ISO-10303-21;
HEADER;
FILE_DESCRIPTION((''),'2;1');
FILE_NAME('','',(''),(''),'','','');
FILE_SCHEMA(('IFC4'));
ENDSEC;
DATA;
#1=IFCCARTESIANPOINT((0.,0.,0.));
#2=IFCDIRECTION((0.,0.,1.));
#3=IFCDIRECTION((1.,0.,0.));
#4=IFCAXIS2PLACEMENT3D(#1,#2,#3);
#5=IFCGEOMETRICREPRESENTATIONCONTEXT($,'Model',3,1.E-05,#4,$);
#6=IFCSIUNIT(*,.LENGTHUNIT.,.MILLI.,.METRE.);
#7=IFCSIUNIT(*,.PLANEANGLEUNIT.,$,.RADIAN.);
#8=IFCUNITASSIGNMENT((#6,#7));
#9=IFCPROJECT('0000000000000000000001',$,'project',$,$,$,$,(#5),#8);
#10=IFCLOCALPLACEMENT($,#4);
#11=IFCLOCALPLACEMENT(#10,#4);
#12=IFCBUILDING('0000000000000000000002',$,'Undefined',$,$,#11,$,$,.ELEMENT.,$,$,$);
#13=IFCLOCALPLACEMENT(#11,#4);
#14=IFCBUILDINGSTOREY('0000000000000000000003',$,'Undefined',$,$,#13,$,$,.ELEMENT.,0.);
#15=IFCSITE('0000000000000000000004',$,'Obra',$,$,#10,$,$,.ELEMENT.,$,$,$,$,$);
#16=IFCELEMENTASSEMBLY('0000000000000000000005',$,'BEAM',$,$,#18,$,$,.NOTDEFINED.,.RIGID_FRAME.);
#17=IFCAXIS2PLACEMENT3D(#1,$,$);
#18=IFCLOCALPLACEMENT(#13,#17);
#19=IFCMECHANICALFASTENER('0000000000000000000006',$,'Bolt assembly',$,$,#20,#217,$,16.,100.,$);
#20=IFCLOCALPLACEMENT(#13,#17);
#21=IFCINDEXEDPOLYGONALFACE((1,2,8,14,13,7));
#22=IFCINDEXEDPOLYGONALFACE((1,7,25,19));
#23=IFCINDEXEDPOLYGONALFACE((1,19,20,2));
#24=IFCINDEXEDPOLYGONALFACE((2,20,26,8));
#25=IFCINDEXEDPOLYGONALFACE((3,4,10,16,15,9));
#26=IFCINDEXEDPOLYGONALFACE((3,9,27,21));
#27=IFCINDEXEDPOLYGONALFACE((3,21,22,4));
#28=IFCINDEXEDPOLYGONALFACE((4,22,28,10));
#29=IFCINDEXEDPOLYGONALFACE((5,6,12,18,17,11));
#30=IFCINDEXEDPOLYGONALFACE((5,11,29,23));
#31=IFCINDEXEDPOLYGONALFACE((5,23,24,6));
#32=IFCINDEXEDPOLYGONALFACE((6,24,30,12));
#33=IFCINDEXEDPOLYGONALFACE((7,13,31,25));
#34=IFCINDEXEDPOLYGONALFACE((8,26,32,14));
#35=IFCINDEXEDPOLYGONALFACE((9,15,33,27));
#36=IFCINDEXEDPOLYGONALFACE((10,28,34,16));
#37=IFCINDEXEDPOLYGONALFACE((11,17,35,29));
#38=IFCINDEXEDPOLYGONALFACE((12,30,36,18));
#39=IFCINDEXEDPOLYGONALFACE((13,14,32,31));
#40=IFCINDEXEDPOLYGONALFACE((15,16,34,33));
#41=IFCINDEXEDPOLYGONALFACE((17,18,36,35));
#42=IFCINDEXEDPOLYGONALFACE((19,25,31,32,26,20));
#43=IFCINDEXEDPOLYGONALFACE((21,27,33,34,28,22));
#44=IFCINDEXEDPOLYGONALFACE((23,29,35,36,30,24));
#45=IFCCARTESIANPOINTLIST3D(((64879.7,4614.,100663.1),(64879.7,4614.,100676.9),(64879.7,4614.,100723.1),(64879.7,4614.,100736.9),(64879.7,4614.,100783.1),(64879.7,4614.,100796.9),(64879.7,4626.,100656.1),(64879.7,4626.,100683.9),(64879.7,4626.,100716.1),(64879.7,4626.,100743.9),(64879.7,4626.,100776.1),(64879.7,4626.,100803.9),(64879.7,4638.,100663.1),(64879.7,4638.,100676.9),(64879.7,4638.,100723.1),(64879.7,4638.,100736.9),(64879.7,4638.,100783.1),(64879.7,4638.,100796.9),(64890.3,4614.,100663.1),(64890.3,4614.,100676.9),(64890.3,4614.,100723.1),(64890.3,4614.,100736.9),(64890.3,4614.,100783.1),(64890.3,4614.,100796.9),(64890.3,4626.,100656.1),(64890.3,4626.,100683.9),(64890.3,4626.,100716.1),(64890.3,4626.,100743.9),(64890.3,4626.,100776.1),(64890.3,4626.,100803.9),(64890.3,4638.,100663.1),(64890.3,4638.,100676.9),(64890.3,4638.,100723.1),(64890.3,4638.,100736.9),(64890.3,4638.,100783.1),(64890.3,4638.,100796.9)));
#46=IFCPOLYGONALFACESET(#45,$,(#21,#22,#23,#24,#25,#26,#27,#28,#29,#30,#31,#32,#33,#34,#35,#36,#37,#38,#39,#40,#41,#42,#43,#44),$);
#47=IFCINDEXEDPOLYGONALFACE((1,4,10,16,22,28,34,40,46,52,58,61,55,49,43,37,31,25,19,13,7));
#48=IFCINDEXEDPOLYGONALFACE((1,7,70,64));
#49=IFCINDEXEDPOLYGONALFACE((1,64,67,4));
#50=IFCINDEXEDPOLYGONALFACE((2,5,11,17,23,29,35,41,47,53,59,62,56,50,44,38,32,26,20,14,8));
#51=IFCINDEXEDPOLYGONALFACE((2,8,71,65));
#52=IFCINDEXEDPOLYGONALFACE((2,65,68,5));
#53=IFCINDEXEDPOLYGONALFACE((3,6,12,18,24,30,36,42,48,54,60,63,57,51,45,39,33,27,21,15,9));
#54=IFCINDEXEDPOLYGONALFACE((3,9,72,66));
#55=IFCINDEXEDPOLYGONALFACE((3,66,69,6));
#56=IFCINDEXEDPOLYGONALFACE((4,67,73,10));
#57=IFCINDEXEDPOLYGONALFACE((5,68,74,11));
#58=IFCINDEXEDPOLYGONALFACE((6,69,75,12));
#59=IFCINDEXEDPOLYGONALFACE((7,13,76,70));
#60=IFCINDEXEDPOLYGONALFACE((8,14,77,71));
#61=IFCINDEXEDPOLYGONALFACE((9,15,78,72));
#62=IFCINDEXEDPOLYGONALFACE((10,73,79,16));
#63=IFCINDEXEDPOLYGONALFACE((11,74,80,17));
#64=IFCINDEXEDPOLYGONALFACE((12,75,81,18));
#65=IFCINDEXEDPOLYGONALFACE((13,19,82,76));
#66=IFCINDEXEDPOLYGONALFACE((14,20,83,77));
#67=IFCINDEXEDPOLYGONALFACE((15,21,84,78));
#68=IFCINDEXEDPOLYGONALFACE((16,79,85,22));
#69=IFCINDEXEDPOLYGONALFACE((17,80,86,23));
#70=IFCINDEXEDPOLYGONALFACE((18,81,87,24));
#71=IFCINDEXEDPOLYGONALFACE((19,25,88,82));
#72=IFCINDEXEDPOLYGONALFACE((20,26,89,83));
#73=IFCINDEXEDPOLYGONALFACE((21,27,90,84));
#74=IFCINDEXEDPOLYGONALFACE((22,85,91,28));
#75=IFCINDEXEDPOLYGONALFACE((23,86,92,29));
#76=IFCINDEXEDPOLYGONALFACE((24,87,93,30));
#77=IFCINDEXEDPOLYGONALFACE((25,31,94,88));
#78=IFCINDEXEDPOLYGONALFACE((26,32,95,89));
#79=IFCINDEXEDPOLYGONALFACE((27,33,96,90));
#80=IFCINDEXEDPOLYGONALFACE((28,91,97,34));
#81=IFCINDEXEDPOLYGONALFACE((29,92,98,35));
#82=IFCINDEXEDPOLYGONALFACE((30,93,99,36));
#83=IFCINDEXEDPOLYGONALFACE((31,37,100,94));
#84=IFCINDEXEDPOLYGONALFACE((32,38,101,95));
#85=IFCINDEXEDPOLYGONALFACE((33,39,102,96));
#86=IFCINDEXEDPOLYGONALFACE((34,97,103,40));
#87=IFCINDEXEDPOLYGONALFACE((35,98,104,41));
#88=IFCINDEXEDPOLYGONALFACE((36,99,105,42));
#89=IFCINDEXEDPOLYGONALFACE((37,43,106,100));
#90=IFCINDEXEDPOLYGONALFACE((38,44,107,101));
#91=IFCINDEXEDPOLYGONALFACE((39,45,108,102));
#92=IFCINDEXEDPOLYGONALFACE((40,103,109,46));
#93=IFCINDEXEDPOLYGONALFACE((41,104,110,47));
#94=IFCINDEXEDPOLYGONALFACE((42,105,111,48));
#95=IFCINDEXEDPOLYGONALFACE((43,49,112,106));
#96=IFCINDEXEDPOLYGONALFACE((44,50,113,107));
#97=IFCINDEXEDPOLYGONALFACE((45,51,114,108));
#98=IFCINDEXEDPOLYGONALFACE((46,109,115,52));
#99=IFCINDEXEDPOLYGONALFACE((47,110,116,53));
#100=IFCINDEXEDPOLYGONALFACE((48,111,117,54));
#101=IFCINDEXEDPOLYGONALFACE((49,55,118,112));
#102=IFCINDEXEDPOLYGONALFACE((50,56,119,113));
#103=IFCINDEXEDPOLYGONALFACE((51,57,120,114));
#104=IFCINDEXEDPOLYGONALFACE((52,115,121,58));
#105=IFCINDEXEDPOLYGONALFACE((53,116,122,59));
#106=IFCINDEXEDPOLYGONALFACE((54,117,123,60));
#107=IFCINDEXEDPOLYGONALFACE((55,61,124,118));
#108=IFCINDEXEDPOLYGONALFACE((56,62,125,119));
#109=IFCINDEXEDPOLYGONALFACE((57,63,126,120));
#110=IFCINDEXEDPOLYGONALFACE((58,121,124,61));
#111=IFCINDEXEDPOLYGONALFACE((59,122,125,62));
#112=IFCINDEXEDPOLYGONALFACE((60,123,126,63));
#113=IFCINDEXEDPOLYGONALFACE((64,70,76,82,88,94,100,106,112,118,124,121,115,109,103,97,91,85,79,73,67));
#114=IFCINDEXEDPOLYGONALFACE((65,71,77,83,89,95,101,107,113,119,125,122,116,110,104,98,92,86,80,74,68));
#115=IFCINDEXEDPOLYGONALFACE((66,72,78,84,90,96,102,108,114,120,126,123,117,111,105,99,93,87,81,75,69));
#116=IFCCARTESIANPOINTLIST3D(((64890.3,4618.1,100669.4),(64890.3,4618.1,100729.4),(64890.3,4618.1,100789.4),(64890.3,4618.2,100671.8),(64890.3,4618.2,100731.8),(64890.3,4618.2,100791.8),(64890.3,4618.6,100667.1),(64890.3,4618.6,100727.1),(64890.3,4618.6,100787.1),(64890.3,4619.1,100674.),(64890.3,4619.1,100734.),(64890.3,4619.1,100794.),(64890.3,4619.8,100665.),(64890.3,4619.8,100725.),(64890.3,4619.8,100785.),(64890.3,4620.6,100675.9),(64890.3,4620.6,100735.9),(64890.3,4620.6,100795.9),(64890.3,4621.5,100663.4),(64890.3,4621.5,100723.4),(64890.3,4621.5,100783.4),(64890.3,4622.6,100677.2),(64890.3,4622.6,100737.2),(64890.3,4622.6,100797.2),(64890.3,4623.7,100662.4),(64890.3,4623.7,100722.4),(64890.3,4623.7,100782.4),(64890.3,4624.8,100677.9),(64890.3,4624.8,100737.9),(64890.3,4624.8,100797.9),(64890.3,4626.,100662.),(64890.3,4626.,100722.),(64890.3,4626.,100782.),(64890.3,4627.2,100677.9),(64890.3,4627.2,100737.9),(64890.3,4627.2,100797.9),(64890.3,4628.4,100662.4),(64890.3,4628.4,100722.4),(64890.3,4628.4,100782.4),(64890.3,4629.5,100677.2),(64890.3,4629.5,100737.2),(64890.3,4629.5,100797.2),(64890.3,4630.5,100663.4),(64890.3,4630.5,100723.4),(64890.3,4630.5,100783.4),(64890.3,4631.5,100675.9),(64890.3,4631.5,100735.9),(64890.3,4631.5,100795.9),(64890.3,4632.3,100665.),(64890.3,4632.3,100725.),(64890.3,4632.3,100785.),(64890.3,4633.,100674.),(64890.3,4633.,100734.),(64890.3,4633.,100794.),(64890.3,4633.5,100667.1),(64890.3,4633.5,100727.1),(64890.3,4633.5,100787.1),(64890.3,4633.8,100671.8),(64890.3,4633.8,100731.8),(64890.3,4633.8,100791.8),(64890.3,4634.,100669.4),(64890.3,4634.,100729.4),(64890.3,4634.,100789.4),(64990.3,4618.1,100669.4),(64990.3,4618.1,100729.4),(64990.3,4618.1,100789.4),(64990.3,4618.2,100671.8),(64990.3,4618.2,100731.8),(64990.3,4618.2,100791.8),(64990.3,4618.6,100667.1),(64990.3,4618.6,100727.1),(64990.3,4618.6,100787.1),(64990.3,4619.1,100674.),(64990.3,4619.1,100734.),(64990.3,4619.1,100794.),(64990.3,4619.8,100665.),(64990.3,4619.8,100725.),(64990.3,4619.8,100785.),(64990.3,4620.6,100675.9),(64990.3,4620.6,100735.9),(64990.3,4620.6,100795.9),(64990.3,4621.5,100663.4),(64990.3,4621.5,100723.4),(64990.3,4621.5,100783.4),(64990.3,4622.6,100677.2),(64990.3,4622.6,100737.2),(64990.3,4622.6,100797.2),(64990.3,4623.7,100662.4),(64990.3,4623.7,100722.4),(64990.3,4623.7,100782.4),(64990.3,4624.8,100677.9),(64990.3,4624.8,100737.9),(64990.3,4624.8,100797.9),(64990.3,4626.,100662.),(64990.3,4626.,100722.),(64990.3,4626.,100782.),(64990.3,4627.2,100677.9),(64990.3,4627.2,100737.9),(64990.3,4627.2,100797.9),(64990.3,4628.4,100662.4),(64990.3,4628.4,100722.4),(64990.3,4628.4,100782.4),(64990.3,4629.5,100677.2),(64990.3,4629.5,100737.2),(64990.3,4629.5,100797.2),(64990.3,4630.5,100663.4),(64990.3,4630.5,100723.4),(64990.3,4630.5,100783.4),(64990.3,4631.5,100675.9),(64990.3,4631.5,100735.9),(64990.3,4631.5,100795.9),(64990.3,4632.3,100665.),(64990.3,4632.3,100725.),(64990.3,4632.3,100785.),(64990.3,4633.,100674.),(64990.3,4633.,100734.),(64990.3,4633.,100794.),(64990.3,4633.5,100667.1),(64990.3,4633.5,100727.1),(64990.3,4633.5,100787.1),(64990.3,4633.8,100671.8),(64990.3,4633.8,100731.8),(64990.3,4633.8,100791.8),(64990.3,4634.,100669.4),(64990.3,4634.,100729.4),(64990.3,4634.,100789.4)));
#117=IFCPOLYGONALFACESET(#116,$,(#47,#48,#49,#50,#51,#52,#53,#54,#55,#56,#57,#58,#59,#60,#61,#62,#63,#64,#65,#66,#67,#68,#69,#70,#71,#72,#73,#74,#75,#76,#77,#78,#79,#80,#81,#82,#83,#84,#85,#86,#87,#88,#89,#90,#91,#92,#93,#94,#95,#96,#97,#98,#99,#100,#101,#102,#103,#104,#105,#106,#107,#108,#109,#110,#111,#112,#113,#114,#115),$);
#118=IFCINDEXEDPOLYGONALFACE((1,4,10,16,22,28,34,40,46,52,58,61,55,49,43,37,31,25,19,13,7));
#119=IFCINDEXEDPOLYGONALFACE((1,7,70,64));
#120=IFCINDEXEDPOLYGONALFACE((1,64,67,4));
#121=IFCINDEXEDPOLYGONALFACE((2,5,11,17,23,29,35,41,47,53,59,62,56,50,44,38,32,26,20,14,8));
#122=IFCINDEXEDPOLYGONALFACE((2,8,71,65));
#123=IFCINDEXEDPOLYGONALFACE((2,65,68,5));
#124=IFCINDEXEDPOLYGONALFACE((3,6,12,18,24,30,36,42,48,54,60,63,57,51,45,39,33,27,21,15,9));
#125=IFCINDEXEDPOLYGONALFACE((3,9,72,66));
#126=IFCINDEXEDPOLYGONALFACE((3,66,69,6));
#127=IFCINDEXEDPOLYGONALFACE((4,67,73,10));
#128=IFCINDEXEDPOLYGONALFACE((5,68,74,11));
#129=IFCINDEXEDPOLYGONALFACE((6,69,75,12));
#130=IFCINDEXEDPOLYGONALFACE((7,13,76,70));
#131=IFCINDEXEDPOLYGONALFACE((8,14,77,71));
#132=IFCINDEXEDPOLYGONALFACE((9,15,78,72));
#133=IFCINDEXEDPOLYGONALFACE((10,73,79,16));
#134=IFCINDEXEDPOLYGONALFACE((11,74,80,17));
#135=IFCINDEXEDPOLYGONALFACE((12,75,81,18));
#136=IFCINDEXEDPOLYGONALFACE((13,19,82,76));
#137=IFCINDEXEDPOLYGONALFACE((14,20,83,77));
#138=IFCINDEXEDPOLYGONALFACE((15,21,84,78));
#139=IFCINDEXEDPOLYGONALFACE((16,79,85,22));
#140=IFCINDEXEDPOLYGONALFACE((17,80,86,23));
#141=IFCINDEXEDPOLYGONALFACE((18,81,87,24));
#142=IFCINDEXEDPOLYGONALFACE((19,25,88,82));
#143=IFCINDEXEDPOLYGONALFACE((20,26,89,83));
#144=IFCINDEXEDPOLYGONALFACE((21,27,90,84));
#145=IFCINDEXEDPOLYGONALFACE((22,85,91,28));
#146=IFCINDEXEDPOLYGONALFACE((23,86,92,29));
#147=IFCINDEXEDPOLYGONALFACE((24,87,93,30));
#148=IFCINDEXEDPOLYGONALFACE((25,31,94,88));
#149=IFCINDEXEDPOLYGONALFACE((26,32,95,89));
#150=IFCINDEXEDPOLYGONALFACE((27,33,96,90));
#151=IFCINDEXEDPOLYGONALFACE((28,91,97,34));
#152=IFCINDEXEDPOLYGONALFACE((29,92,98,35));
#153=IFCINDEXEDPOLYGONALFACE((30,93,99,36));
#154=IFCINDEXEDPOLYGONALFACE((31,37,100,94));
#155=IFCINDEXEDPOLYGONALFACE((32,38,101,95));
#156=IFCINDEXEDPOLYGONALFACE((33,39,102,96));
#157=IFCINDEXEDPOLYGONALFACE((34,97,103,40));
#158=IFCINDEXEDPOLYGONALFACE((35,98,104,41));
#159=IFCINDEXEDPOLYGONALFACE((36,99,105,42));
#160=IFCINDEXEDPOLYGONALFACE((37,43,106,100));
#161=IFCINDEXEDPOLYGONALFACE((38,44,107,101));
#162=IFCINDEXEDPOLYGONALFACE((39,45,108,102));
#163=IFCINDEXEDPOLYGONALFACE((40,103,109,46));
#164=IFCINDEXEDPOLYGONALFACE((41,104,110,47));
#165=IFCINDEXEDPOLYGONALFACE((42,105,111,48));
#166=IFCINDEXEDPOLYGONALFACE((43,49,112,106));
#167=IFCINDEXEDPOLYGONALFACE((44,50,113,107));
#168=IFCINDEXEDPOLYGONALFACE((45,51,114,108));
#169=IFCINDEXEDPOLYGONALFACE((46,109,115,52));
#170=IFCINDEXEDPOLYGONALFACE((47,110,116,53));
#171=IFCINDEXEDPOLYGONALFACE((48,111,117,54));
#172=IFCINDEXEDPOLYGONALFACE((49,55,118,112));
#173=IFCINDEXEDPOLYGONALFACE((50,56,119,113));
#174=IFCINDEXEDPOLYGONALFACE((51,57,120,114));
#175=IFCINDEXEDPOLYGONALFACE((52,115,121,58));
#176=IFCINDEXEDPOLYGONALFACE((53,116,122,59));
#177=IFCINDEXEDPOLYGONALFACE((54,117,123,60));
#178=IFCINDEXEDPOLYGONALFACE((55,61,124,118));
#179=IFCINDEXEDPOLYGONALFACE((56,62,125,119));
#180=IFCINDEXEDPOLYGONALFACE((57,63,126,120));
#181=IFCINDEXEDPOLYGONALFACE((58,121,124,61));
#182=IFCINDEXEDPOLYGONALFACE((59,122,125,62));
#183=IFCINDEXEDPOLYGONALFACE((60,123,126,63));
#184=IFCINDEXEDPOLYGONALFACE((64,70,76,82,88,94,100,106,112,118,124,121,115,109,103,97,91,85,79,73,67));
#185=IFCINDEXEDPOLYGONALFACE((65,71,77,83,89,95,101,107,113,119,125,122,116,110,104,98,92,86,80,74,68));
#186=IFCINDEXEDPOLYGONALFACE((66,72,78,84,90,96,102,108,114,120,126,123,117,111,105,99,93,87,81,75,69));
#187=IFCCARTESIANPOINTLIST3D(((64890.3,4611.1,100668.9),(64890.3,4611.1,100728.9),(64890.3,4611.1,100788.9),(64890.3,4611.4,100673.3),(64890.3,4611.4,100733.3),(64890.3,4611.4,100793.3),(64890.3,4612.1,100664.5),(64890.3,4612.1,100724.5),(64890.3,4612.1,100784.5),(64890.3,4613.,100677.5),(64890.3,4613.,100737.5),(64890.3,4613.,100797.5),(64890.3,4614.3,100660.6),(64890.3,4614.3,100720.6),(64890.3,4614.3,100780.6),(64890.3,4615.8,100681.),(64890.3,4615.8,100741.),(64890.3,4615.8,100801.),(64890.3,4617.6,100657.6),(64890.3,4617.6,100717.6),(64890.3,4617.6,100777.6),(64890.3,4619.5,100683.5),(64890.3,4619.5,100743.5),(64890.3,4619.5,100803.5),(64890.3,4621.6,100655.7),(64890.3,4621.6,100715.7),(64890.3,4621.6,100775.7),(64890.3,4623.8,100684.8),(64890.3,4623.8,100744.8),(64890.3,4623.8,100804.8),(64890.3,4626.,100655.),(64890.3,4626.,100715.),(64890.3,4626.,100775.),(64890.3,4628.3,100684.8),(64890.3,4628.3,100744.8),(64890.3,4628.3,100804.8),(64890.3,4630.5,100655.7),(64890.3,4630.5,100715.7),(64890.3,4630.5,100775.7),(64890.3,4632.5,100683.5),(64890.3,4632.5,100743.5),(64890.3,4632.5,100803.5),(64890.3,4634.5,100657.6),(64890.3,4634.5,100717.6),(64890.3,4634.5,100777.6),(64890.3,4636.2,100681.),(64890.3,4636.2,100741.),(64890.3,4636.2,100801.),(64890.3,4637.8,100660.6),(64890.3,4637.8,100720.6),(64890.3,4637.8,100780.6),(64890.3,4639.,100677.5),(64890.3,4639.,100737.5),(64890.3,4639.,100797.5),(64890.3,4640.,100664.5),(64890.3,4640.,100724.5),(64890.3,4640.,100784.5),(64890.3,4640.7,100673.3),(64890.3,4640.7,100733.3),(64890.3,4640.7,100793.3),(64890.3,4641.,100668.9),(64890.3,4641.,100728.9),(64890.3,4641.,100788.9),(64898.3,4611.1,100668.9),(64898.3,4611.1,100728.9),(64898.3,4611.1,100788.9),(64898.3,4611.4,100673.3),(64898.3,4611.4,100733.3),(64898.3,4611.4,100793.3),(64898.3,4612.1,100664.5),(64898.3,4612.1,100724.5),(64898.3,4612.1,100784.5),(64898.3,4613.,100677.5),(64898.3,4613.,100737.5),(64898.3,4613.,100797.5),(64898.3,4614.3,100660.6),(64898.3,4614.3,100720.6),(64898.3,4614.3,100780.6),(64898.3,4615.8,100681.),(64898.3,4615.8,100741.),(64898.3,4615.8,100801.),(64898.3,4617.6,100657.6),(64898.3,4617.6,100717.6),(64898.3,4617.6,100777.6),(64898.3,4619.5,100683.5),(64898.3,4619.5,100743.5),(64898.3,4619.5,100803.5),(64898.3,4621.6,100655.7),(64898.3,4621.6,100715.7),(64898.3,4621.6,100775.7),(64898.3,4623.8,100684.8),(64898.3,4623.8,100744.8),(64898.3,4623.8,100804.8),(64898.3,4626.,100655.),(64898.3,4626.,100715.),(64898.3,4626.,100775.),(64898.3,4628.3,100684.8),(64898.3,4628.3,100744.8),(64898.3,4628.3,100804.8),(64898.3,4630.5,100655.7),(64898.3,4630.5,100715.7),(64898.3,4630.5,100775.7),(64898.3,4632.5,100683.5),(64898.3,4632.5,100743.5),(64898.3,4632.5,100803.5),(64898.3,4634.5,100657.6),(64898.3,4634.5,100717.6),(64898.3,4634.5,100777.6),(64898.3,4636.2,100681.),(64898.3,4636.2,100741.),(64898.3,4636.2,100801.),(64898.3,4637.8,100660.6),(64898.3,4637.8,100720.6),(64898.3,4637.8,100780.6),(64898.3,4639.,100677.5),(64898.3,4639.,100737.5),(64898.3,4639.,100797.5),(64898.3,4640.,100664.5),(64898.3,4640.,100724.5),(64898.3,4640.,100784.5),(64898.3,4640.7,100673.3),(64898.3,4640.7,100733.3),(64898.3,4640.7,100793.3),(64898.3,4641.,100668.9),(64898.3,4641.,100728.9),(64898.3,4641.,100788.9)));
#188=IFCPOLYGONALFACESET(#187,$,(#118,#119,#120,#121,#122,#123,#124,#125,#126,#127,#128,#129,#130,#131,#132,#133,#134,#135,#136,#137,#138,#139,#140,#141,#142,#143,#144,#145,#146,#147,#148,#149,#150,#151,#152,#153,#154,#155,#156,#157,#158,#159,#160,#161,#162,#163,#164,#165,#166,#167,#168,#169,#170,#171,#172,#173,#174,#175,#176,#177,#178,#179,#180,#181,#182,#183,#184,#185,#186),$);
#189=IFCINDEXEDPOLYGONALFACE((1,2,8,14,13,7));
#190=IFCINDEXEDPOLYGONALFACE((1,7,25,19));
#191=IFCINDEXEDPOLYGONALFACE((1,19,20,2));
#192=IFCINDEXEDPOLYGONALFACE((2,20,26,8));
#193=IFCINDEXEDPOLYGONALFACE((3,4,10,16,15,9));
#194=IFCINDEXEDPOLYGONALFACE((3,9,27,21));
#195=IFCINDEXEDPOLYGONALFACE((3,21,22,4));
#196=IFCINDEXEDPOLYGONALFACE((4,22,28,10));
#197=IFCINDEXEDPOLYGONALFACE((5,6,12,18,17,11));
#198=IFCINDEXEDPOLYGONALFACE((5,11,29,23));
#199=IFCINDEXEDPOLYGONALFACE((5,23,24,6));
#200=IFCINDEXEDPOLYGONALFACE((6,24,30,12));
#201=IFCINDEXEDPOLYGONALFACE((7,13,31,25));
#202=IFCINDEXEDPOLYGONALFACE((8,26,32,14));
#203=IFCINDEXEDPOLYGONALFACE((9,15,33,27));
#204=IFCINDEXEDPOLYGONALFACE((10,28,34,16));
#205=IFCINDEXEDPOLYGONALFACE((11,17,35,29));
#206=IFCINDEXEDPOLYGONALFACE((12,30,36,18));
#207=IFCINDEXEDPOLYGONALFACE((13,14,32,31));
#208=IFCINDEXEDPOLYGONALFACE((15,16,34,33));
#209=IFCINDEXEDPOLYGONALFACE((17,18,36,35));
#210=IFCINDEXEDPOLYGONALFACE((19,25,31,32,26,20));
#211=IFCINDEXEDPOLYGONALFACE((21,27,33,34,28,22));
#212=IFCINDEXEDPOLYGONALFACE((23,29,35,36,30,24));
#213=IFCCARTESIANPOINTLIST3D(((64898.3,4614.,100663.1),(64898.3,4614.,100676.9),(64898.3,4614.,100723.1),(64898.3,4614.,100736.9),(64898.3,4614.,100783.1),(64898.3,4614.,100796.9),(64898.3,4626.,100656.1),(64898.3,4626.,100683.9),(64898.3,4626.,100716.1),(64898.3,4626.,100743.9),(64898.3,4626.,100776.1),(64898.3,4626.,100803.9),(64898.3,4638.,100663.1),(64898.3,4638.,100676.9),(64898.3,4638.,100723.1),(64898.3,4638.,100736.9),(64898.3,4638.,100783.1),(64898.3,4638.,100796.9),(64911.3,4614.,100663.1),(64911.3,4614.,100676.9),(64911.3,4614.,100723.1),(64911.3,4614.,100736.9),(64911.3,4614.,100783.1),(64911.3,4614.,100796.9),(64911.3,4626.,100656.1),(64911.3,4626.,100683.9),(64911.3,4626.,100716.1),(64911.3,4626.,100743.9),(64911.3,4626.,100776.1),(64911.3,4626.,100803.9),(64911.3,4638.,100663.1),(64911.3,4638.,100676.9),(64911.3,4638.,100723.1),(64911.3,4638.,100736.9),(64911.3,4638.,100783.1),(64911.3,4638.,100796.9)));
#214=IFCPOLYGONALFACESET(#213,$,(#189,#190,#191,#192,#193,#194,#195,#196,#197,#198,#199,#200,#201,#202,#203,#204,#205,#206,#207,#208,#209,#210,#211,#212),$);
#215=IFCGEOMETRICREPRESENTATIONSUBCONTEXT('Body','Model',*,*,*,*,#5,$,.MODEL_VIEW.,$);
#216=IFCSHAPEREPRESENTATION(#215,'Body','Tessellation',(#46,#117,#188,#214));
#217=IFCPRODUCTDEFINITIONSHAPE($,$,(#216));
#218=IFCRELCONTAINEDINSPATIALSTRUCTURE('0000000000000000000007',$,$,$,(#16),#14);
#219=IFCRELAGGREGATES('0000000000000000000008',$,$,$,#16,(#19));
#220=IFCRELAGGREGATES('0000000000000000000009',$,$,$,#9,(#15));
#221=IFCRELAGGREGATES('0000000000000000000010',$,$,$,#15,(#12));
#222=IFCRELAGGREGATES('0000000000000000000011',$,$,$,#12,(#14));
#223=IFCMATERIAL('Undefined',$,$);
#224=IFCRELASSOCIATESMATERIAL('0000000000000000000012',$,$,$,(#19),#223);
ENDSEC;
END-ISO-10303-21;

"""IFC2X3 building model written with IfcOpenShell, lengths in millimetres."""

from ifc_helpers import new_model, si_unit, frame, origin_with_axes, origin_2d_with_axis, place, context, subcontext, project, spatial, polyline, circle, outline, extrude, source, transform, mapped, material, element, aggregate, save


model = new_model("IFC2X3")

# Units and contexts
model_context = context("Model", 3, precision=1e-05, world=origin_with_axes())
body_context = subcontext(model_context, "Body", "Model", "MODEL_VIEW")
ifc_project = project(units=[si_unit("LENGTHUNIT", "METRE", prefix="MILLI"), si_unit("PLANEANGLEUNIT", "RADIAN")], contexts=[model_context])

# Site, building, storey
site_placement = place(None, origin_with_axes())
site = spatial("IfcSite", under=ifc_project, at=site_placement, Name="Obra", CompositionType="ELEMENT")
building_placement = place(site_placement, origin_with_axes())
building = spatial("IfcBuilding", under=site, at=building_placement, Name="Undefined", CompositionType="ELEMENT")
storey_placement = place(building_placement, origin_with_axes())
storey = spatial("IfcBuildingStorey", under=building, at=storey_placement, Name="Undefined", CompositionType="ELEMENT", Elevation=0.0)

# Shared definitions
ifc_material_1 = material(Name="Undefined")

# Element assembly, mechanical fastener
assembly_1_placement = place(storey_placement, origin_with_axes())
assembly_1 = element("IfcElementAssembly", 1, at=assembly_1_placement, inside=storey, Name="BEAM", AssemblyPlace="NOTDEFINED", PredefinedType="RIGID_FRAME")
shared_shape_1 = source(origin_with_axes(), body_context, "Body", "SweptSolid", [
    extrude(outline(polyline([(13.9, 0.0), (6.9, 12.0), (-6.9, 12.0), (-13.9, 0.0), (-6.9, -12.0), (6.9, -12.0), (13.9, 0.0)])), frame((0.0, -10.6, 0.0), z_axis=(0.0, 1.0, 0.0), x_axis=(1.0, 0.0, 0.0)), (0.0, 0.0, 1.0), 10.6),
    extrude(circle(Radius=8.0, at=origin_2d_with_axis()), frame((0.0, 0.0, 0.0), z_axis=(0.0, 1.0, 0.0), x_axis=(1.0, 0.0, 0.0)), (0.0, 0.0, 1.0), 100.0),
    extrude(circle(Radius=15.0, at=origin_2d_with_axis()), frame((0.0, 0.0, 0.0), z_axis=(0.0, 1.0, 0.0), x_axis=(1.0, 0.0, 0.0)), (0.0, 0.0, 1.0), 8.0),
    extrude(outline(polyline([(13.9, 0.0), (6.9, 12.0), (-6.9, 12.0), (-13.9, 0.0), (-6.9, -12.0), (6.9, -12.0), (13.9, 0.0)])), frame((0.0, 8.0, 0.0), z_axis=(0.0, 1.0, 0.0), x_axis=(1.0, 0.0, 0.0)), (0.0, 0.0, 1.0), 13.0),
])
mechanical_fastener_1_placement = place(assembly_1_placement, frame((64890.3, 4676.0, 100850.0), z_axis=(0.0, -1.0, 0.0), x_axis=(0.0, 0.0, -1.0)))
mechanical_fastener_1 = element("IfcMechanicalFastener", 2, at=mechanical_fastener_1_placement, material=ifc_material_1, Name="Bolt assembly", NominalDiameter=16.0, NominalLength=100.0, context=body_context, shape_type="MappedRepresentation", body=[
    mapped(shared_shape_1, transform((60.0, 0.0, 50.0))),
    mapped(shared_shape_1, transform((120.0, 0.0, 50.0))),
    mapped(shared_shape_1, transform((180.0, 0.0, 50.0))),
])
aggregate(assembly_1, [mechanical_fastener_1])

save(model, "model.ifc")
